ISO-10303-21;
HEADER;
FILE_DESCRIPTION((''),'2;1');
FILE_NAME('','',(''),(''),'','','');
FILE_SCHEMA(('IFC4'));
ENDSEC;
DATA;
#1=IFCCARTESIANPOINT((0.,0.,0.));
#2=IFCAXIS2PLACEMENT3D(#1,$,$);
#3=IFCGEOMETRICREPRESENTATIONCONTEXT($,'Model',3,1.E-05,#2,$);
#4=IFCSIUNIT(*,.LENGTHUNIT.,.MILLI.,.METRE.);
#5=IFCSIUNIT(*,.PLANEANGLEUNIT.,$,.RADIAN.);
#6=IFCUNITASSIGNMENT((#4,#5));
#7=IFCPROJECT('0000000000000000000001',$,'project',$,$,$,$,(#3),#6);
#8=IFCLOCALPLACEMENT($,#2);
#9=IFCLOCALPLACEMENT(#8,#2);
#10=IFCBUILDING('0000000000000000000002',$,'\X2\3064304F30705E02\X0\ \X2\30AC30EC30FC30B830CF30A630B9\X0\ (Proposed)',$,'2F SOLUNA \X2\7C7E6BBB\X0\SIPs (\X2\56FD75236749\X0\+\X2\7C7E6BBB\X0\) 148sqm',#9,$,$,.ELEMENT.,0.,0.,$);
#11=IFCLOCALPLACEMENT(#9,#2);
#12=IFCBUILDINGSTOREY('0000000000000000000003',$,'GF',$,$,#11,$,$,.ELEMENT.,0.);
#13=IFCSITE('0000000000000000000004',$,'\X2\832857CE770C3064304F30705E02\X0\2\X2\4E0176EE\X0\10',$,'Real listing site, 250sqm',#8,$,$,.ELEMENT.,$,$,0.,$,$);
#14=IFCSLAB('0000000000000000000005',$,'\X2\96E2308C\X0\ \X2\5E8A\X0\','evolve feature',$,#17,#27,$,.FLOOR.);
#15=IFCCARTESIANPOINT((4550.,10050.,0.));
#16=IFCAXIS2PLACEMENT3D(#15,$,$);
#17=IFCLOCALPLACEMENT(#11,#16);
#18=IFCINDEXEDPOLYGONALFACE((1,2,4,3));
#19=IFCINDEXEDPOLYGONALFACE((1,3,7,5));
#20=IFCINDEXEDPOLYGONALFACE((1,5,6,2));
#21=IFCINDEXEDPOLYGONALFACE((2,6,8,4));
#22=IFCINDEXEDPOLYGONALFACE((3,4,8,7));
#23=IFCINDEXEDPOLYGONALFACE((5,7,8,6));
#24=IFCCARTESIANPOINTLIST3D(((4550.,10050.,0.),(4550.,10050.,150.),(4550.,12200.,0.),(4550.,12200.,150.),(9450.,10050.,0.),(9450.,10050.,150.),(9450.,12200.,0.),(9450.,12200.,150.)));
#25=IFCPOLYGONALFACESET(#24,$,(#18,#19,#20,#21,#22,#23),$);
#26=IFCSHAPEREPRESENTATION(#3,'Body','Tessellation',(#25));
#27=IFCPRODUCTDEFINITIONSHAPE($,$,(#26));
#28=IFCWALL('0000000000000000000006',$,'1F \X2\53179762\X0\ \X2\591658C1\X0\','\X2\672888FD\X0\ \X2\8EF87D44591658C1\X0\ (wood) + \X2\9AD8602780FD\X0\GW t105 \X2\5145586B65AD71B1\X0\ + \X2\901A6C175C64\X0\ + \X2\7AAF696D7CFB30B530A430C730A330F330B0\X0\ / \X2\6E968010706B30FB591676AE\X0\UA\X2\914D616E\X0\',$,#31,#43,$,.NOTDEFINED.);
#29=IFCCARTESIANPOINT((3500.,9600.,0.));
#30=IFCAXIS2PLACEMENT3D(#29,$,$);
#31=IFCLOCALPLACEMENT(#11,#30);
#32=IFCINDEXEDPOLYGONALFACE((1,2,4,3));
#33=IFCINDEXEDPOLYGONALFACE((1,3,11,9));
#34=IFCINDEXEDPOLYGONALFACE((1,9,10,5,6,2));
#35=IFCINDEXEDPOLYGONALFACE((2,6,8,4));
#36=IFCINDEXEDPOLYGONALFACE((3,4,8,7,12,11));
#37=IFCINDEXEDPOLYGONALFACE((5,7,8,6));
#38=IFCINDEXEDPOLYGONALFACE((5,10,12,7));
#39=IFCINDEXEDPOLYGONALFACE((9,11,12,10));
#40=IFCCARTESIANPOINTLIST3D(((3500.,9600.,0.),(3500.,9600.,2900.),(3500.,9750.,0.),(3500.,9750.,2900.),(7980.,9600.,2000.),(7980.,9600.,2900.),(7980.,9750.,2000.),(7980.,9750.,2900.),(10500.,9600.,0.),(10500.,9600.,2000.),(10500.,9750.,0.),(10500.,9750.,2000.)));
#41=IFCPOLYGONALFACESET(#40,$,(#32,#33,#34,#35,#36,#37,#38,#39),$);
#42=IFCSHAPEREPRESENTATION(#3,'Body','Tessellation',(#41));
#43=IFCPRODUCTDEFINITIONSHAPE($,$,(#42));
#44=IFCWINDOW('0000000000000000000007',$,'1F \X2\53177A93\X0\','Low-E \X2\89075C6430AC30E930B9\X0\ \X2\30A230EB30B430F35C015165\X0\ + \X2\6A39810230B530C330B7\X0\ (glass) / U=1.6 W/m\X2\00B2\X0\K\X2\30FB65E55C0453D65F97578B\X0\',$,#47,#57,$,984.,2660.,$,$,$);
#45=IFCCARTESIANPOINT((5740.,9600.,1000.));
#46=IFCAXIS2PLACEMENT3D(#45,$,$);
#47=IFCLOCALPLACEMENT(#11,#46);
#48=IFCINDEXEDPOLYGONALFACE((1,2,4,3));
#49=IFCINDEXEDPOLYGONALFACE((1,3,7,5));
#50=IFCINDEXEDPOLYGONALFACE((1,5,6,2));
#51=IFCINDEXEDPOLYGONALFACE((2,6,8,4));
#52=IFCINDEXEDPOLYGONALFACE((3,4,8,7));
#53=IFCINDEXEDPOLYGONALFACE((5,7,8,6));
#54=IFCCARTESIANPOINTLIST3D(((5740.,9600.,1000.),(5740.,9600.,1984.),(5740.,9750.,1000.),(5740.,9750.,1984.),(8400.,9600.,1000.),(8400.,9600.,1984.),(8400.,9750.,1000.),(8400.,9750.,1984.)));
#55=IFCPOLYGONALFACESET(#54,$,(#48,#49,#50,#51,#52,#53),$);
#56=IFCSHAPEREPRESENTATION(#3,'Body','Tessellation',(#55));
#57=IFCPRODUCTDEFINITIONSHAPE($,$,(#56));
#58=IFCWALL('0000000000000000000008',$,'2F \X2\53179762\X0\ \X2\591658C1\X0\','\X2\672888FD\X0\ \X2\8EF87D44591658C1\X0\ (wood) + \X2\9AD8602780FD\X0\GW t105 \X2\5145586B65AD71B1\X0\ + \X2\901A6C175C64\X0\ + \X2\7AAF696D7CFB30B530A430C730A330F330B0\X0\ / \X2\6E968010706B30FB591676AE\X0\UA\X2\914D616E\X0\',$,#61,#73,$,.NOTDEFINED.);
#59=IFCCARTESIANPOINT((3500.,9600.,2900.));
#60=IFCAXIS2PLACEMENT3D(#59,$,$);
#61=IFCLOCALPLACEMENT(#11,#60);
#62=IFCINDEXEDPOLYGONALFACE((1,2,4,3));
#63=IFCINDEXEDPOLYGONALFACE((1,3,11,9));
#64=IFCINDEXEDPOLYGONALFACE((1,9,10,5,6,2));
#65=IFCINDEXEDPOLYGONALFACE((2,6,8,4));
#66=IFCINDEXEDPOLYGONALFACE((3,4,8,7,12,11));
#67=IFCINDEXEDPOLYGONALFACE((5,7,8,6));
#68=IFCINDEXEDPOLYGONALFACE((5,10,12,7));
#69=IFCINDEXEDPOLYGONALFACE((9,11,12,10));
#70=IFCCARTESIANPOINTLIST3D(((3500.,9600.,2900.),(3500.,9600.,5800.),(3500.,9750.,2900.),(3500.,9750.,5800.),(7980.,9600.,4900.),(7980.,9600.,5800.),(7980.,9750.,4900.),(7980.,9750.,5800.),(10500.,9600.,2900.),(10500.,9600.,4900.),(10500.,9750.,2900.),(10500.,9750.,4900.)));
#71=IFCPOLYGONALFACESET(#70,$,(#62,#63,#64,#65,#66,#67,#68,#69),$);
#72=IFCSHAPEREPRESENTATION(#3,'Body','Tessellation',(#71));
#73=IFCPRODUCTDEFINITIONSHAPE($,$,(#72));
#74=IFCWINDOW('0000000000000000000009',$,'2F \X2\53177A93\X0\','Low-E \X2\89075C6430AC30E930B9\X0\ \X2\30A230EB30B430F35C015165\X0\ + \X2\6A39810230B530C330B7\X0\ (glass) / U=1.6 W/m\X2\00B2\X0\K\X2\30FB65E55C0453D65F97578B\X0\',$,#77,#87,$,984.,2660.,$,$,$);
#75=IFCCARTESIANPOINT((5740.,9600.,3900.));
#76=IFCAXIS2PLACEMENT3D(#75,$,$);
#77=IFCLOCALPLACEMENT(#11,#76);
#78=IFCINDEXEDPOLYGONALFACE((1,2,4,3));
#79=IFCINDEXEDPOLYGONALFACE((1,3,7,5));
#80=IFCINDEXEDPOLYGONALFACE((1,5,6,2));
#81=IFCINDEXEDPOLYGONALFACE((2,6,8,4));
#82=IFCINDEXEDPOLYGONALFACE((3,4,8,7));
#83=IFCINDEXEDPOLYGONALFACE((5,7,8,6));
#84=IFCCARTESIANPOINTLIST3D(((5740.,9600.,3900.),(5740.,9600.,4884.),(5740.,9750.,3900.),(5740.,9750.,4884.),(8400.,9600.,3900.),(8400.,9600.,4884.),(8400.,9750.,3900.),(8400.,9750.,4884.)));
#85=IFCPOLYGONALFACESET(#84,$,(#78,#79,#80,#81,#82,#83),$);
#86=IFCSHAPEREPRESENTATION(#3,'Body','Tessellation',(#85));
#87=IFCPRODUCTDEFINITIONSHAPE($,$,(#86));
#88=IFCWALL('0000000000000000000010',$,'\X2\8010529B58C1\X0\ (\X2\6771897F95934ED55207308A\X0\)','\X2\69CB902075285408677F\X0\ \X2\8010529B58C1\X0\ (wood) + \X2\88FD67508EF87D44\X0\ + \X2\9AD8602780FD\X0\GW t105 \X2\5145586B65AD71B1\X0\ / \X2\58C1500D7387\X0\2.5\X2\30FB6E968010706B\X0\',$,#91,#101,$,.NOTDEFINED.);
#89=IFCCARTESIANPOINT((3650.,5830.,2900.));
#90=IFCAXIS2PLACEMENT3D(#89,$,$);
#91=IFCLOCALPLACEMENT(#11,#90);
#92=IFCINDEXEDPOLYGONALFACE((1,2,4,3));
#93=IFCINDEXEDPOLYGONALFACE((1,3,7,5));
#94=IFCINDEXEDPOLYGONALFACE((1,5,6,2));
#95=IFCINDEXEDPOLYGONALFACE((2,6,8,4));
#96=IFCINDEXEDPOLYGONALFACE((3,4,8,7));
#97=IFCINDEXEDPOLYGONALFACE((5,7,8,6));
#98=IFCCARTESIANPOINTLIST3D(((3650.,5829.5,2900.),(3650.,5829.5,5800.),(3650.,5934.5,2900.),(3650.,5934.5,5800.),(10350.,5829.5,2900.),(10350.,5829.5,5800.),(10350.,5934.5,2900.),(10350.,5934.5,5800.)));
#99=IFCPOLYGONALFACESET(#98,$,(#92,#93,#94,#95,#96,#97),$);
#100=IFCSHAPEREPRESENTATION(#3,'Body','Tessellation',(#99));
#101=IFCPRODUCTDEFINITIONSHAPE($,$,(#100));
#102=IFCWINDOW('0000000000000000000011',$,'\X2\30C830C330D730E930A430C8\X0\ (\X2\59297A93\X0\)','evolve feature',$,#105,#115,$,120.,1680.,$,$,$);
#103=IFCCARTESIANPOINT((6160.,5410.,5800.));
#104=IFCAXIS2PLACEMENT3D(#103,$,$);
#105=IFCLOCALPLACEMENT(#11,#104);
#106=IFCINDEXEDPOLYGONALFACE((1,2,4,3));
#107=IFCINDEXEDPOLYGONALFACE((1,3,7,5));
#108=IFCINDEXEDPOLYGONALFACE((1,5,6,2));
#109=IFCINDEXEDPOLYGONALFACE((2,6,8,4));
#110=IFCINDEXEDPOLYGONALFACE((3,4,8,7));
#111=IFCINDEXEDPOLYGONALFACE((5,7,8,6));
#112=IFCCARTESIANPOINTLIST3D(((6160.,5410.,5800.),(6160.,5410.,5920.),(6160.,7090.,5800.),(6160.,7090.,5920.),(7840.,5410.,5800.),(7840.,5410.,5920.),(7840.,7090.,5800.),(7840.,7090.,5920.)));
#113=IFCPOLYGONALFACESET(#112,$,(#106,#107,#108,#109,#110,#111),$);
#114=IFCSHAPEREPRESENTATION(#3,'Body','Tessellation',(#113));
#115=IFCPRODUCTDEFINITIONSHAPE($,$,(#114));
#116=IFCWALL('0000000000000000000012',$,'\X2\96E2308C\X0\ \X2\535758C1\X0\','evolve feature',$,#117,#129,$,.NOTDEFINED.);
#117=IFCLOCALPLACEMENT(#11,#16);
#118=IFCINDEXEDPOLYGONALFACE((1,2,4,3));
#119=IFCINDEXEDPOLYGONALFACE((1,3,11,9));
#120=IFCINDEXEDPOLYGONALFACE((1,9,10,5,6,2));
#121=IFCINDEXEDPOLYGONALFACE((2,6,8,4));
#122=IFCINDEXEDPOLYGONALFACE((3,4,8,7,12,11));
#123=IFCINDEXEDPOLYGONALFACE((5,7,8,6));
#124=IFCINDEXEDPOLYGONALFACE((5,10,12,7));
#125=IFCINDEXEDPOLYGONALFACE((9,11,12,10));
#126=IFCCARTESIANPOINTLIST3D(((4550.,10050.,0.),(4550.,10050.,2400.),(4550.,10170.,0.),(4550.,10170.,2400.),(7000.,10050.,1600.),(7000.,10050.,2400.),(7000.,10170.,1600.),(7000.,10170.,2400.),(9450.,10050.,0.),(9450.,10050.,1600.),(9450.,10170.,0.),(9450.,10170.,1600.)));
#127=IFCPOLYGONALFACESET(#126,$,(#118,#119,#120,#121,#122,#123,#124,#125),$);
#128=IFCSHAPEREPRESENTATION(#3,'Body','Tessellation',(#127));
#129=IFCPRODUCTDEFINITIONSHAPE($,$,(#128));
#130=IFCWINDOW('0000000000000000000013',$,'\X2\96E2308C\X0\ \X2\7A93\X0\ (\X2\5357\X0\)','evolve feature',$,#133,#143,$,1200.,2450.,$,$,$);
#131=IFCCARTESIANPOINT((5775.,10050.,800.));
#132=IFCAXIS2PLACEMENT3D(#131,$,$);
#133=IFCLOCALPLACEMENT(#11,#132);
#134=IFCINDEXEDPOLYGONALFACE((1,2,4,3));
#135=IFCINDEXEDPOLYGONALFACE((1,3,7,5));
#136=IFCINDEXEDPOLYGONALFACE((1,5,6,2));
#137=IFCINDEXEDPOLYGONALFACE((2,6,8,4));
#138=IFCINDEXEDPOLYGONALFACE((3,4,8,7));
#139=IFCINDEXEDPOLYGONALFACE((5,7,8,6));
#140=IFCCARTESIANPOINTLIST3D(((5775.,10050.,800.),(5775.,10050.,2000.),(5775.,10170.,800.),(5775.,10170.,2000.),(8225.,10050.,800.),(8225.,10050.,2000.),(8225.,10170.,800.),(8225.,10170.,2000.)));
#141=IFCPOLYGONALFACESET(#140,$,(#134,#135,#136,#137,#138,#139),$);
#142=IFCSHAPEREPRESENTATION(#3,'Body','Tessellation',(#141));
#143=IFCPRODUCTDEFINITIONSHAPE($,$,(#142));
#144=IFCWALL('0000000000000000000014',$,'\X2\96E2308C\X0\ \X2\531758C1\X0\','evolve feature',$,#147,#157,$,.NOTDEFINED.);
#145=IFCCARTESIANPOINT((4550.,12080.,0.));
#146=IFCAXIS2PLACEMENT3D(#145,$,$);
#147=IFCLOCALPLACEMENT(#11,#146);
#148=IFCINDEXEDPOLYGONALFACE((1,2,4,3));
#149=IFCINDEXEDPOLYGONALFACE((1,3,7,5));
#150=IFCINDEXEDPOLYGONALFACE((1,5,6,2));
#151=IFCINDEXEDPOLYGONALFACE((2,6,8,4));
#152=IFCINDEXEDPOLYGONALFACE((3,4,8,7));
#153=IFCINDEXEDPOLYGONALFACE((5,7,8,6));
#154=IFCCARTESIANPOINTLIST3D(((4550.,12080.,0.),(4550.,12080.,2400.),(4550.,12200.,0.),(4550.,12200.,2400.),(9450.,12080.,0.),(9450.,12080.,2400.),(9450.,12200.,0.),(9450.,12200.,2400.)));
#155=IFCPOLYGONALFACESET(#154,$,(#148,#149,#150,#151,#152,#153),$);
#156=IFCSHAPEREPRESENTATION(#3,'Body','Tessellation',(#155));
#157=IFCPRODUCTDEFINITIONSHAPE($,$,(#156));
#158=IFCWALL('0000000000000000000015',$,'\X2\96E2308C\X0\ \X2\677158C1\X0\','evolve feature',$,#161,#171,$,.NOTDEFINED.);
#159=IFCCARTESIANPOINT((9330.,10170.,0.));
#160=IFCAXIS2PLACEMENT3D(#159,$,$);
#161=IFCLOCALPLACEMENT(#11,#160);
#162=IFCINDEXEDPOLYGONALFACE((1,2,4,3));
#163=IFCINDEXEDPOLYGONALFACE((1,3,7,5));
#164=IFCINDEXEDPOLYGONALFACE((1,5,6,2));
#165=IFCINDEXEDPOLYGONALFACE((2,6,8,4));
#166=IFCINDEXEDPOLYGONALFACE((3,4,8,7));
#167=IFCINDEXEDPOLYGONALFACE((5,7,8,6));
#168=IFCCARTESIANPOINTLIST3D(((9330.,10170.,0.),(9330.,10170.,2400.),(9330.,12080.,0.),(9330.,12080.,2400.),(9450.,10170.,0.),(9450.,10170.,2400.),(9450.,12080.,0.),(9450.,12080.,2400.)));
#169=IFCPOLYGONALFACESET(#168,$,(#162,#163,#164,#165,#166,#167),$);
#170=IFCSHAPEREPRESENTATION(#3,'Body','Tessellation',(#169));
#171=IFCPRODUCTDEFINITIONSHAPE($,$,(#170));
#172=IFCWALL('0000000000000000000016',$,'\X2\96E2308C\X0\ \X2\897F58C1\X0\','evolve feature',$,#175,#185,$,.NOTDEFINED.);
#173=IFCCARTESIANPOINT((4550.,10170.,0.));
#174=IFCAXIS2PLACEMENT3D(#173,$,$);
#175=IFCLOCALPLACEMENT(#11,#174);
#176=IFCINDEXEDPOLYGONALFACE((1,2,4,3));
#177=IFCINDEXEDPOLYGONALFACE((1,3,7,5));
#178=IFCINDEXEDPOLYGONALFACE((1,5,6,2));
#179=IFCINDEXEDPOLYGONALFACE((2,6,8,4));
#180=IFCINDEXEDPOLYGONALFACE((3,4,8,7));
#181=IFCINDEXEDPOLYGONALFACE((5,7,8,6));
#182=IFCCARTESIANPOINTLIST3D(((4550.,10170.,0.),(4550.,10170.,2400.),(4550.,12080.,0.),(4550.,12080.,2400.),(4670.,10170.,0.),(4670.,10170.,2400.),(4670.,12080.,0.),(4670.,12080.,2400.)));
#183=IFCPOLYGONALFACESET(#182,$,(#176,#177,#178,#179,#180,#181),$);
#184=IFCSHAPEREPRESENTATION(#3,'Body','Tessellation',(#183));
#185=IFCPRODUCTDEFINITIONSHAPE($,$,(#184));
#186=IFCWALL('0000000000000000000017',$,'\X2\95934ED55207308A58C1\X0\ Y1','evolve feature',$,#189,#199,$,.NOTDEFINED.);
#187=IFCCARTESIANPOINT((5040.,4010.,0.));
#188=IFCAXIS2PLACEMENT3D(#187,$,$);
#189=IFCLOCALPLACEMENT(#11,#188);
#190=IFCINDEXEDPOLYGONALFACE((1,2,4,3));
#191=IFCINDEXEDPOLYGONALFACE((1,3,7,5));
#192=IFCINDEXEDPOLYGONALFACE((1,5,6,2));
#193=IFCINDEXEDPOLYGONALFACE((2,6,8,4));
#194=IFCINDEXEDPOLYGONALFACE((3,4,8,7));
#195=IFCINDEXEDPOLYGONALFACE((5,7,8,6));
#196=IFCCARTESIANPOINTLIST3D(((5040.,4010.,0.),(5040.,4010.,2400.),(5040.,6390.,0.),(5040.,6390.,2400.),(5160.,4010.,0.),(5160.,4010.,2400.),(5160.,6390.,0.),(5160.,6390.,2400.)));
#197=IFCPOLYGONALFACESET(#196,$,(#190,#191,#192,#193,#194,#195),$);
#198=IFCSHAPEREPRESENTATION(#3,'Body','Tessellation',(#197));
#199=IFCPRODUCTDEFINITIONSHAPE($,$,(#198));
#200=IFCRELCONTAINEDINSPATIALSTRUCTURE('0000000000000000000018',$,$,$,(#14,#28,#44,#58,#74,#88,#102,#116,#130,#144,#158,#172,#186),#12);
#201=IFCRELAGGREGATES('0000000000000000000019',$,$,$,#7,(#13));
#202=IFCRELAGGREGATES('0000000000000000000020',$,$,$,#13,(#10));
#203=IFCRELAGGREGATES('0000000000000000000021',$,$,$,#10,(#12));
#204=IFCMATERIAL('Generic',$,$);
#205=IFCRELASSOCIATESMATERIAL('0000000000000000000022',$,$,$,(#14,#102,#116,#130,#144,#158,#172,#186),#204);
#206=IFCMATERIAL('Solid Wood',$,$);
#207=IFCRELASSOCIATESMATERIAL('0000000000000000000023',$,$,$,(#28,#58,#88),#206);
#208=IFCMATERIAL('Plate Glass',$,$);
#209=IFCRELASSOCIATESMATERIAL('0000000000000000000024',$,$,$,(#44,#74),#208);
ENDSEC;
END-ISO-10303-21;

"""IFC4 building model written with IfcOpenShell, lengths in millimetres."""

from ifc_helpers import new_model, si_unit, frame, frame_2d, origin, place, context, project, spatial, rectangle, extrude, material, element, fill, save


model = new_model("IFC4")

# Units and contexts
model_context = context("Model", 3, precision=1e-05, world=origin())
ifc_project = project(units=[si_unit("LENGTHUNIT", "METRE", prefix="MILLI"), si_unit("PLANEANGLEUNIT", "RADIAN")], contexts=[model_context])

# Site, building, storey
site_placement = place(None, origin())
site = spatial("IfcSite", under=ifc_project, at=site_placement, Name="茨城県つくば市2丁目10", ObjectType="Real listing site, 250sqm", CompositionType="ELEMENT", RefElevation=0.0)
building_placement = place(site_placement, origin())
building = spatial("IfcBuilding", under=site, at=building_placement, Name="つくば市 ガレージハウス (Proposed)", ObjectType="2F SOLUNA 籾殻SIPs (国産杉+籾殻) 148sqm", CompositionType="ELEMENT", ElevationOfRefHeight=0.0, ElevationOfTerrain=0.0)
storey_placement = place(building_placement, origin())
storey = spatial("IfcBuildingStorey", under=building, at=storey_placement, Name="GF", CompositionType="ELEMENT", Elevation=0.0)

# Slab
ifc_material_1 = material(Name="Generic")
slab_placement = place(storey_placement, frame((4550.0, 10050.0, 0.0)))
element("IfcSlab", 1, at=slab_placement, inside=storey, material=ifc_material_1, Name="離れ 床", Description="evolve feature", PredefinedType="FLOOR", context=model_context, shape_type="SweptSolid", body=[
    extrude(rectangle(XDim=4900.0, YDim=2150.0, at=frame_2d((2450.0, 1075.0))), frame((4550.0, 10050.0, 0.0)), (0.0, 0.0, 1.0), 150.0),
])

# Wall, opening, window
ifc_material_2 = material(Name="Solid Wood")
wall_1_placement = place(storey_placement, frame((3500.0, 9600.0, 0.0)))
wall_1 = element("IfcWall", 2, at=wall_1_placement, inside=storey, material=ifc_material_2, Name="1F 北面 外壁", Description="木製 軸組外壁 (wood) + 高性能GW t105 充填断熱 + 通気層 + 窯業系サイディング / 準耐火・外皮UA配慮", PredefinedType="NOTDEFINED", context=model_context, shape_type="SweptSolid", body=[
    extrude(rectangle(XDim=7000.0, YDim=150.0, at=frame_2d((3500.0, 75.0))), frame((3500.0, 9600.0, 0.0)), (0.0, 0.0, 1.0), 2900.0),
])
opening_1_placement = place(storey_placement, frame((5740.0, 9600.0, 1000.0)))
opening_1 = element("IfcOpeningElement", 3, at=opening_1_placement, cuts=wall_1, PredefinedType="NOTDEFINED", context=model_context, shape_type="SweptSolid", body=[
    extrude(rectangle(XDim=2660.0, YDim=150.0, at=frame_2d((1330.0, 75.0))), frame((5740.0, 9600.0, 1000.0)), (0.0, 0.0, 1.0), 984.0),
])
ifc_material_3 = material(Name="Plate Glass")
window_1_placement = place(storey_placement, frame((5740.0, 9600.0, 1000.0)))
window_1 = element("IfcWindow", 4, at=window_1_placement, inside=storey, material=ifc_material_3, Name="1F 北窓", Description="Low-E 複層ガラス アルゴン封入 + 樹脂サッシ (glass) / U=1.6 W/m²K・日射取得型", OverallHeight=984.0, OverallWidth=2660.0, context=model_context, shape_type="SweptSolid", body=[
    extrude(rectangle(XDim=2660.0, YDim=150.0, at=frame_2d((1330.0, 75.0))), frame((5740.0, 9600.0, 1000.0)), (0.0, 0.0, 1.0), 984.0),
])
fill(opening_1, window_1)

# Wall, opening, window
wall_2_placement = place(storey_placement, frame((3500.0, 9600.0, 2900.0)))
wall_2 = element("IfcWall", 5, at=wall_2_placement, inside=storey, material=ifc_material_2, Name="2F 北面 外壁", Description="木製 軸組外壁 (wood) + 高性能GW t105 充填断熱 + 通気層 + 窯業系サイディング / 準耐火・外皮UA配慮", PredefinedType="NOTDEFINED", context=model_context, shape_type="SweptSolid", body=[
    extrude(rectangle(XDim=7000.0, YDim=150.0, at=frame_2d((3500.0, 75.0))), frame((3500.0, 9600.0, 2900.0)), (0.0, 0.0, 1.0), 2900.0),
])
opening_2_placement = place(storey_placement, frame((5740.0, 9600.0, 3900.0)))
opening_2 = element("IfcOpeningElement", 6, at=opening_2_placement, cuts=wall_2, PredefinedType="NOTDEFINED", context=model_context, shape_type="SweptSolid", body=[
    extrude(rectangle(XDim=2660.0, YDim=150.0, at=frame_2d((1330.0, 75.0))), frame((5740.0, 9600.0, 3900.0)), (0.0, 0.0, 1.0), 984.0),
])
window_2_placement = place(storey_placement, frame((5740.0, 9600.0, 3900.0)))
window_2 = element("IfcWindow", 7, at=window_2_placement, inside=storey, material=ifc_material_3, Name="2F 北窓", Description="Low-E 複層ガラス アルゴン封入 + 樹脂サッシ (glass) / U=1.6 W/m²K・日射取得型", OverallHeight=984.0, OverallWidth=2660.0, context=model_context, shape_type="SweptSolid", body=[
    extrude(rectangle(XDim=2660.0, YDim=150.0, at=frame_2d((1330.0, 75.0))), frame((5740.0, 9600.0, 3900.0)), (0.0, 0.0, 1.0), 984.0),
])
fill(opening_2, window_2)

# Wall
wall_3_placement = place(storey_placement, frame((3650.0, 5830.0, 2900.0)))
element("IfcWall", 8, at=wall_3_placement, inside=storey, material=ifc_material_2, Name="耐力壁 (東西間仕切り)", Description="構造用合板 耐力壁 (wood) + 製材軸組 + 高性能GW t105 充填断熱 / 壁倍率2.5・準耐火", PredefinedType="NOTDEFINED", context=model_context, shape_type="SweptSolid", body=[
    extrude(rectangle(XDim=6700.0, YDim=105.0, at=frame_2d((3350.0, 52.0))), frame((3650.0, 5830.0, 2900.0)), (0.0, 0.0, 1.0), 2900.0),
])

# Window
window_3_placement = place(storey_placement, frame((6160.0, 5410.0, 5800.0)))
element("IfcWindow", 9, at=window_3_placement, inside=storey, material=ifc_material_1, Name="トップライト (天窓)", Description="evolve feature", OverallHeight=120.0, OverallWidth=1680.0, context=model_context, shape_type="SweptSolid", body=[
    extrude(rectangle(XDim=1680.0, YDim=1680.0, at=frame_2d((840.0, 840.0))), frame((6160.0, 5410.0, 5800.0)), (0.0, 0.0, 1.0), 120.0),
])

# Wall, opening, window
wall_4_placement = place(storey_placement, frame((4550.0, 10050.0, 0.0)))
wall_4 = element("IfcWall", 10, at=wall_4_placement, inside=storey, material=ifc_material_1, Name="離れ 南壁", Description="evolve feature", PredefinedType="NOTDEFINED", context=model_context, shape_type="SweptSolid", body=[
    extrude(rectangle(XDim=4900.0, YDim=120.0, at=frame_2d((2450.0, 60.0))), frame((4550.0, 10050.0, 0.0)), (0.0, 0.0, 1.0), 2400.0),
])
opening_3_placement = place(storey_placement, frame((5775.0, 10050.0, 800.0)))
opening_3 = element("IfcOpeningElement", 11, at=opening_3_placement, cuts=wall_4, PredefinedType="NOTDEFINED", context=model_context, shape_type="SweptSolid", body=[
    extrude(rectangle(XDim=2450.0, YDim=120.0, at=frame_2d((1225.0, 60.0))), frame((5775.0, 10050.0, 800.0)), (0.0, 0.0, 1.0), 1200.0),
])
window_4_placement = place(storey_placement, frame((5775.0, 10050.0, 800.0)))
window_4 = element("IfcWindow", 12, at=window_4_placement, inside=storey, material=ifc_material_1, Name="離れ 窓 (南)", Description="evolve feature", OverallHeight=1200.0, OverallWidth=2450.0, context=model_context, shape_type="SweptSolid", body=[
    extrude(rectangle(XDim=2450.0, YDim=120.0, at=frame_2d((1225.0, 60.0))), frame((5775.0, 10050.0, 800.0)), (0.0, 0.0, 1.0), 1200.0),
])
fill(opening_3, window_4)

# Walls
wall_5_placement = place(storey_placement, frame((4550.0, 12080.0, 0.0)))
element("IfcWall", 13, at=wall_5_placement, inside=storey, material=ifc_material_1, Name="離れ 北壁", Description="evolve feature", PredefinedType="NOTDEFINED", context=model_context, shape_type="SweptSolid", body=[
    extrude(rectangle(XDim=4900.0, YDim=120.0, at=frame_2d((2450.0, 60.0))), frame((4550.0, 12080.0, 0.0)), (0.0, 0.0, 1.0), 2400.0),
])
wall_6_placement = place(storey_placement, frame((9330.0, 10170.0, 0.0)))
element("IfcWall", 14, at=wall_6_placement, inside=storey, material=ifc_material_1, Name="離れ 東壁", Description="evolve feature", PredefinedType="NOTDEFINED", context=model_context, shape_type="SweptSolid", body=[
    extrude(rectangle(XDim=120.0, YDim=1910.0, at=frame_2d((60.0, 955.0))), frame((9330.0, 10170.0, 0.0)), (0.0, 0.0, 1.0), 2400.0),
])
wall_7_placement = place(storey_placement, frame((4550.0, 10170.0, 0.0)))
element("IfcWall", 15, at=wall_7_placement, inside=storey, material=ifc_material_1, Name="離れ 西壁", Description="evolve feature", PredefinedType="NOTDEFINED", context=model_context, shape_type="SweptSolid", body=[
    extrude(rectangle(XDim=120.0, YDim=1910.0, at=frame_2d((60.0, 955.0))), frame((4550.0, 10170.0, 0.0)), (0.0, 0.0, 1.0), 2400.0),
])
wall_8_placement = place(storey_placement, frame((5040.0, 4010.0, 0.0)))
element("IfcWall", 16, at=wall_8_placement, inside=storey, material=ifc_material_1, Name="間仕切り壁 Y1", Description="evolve feature", PredefinedType="NOTDEFINED", context=model_context, shape_type="SweptSolid", body=[
    extrude(rectangle(XDim=120.0, YDim=2380.0, at=frame_2d((60.0, 1190.0))), frame((5040.0, 4010.0, 0.0)), (0.0, 0.0, 1.0), 2400.0),
])

save(model, "model.ifc")
